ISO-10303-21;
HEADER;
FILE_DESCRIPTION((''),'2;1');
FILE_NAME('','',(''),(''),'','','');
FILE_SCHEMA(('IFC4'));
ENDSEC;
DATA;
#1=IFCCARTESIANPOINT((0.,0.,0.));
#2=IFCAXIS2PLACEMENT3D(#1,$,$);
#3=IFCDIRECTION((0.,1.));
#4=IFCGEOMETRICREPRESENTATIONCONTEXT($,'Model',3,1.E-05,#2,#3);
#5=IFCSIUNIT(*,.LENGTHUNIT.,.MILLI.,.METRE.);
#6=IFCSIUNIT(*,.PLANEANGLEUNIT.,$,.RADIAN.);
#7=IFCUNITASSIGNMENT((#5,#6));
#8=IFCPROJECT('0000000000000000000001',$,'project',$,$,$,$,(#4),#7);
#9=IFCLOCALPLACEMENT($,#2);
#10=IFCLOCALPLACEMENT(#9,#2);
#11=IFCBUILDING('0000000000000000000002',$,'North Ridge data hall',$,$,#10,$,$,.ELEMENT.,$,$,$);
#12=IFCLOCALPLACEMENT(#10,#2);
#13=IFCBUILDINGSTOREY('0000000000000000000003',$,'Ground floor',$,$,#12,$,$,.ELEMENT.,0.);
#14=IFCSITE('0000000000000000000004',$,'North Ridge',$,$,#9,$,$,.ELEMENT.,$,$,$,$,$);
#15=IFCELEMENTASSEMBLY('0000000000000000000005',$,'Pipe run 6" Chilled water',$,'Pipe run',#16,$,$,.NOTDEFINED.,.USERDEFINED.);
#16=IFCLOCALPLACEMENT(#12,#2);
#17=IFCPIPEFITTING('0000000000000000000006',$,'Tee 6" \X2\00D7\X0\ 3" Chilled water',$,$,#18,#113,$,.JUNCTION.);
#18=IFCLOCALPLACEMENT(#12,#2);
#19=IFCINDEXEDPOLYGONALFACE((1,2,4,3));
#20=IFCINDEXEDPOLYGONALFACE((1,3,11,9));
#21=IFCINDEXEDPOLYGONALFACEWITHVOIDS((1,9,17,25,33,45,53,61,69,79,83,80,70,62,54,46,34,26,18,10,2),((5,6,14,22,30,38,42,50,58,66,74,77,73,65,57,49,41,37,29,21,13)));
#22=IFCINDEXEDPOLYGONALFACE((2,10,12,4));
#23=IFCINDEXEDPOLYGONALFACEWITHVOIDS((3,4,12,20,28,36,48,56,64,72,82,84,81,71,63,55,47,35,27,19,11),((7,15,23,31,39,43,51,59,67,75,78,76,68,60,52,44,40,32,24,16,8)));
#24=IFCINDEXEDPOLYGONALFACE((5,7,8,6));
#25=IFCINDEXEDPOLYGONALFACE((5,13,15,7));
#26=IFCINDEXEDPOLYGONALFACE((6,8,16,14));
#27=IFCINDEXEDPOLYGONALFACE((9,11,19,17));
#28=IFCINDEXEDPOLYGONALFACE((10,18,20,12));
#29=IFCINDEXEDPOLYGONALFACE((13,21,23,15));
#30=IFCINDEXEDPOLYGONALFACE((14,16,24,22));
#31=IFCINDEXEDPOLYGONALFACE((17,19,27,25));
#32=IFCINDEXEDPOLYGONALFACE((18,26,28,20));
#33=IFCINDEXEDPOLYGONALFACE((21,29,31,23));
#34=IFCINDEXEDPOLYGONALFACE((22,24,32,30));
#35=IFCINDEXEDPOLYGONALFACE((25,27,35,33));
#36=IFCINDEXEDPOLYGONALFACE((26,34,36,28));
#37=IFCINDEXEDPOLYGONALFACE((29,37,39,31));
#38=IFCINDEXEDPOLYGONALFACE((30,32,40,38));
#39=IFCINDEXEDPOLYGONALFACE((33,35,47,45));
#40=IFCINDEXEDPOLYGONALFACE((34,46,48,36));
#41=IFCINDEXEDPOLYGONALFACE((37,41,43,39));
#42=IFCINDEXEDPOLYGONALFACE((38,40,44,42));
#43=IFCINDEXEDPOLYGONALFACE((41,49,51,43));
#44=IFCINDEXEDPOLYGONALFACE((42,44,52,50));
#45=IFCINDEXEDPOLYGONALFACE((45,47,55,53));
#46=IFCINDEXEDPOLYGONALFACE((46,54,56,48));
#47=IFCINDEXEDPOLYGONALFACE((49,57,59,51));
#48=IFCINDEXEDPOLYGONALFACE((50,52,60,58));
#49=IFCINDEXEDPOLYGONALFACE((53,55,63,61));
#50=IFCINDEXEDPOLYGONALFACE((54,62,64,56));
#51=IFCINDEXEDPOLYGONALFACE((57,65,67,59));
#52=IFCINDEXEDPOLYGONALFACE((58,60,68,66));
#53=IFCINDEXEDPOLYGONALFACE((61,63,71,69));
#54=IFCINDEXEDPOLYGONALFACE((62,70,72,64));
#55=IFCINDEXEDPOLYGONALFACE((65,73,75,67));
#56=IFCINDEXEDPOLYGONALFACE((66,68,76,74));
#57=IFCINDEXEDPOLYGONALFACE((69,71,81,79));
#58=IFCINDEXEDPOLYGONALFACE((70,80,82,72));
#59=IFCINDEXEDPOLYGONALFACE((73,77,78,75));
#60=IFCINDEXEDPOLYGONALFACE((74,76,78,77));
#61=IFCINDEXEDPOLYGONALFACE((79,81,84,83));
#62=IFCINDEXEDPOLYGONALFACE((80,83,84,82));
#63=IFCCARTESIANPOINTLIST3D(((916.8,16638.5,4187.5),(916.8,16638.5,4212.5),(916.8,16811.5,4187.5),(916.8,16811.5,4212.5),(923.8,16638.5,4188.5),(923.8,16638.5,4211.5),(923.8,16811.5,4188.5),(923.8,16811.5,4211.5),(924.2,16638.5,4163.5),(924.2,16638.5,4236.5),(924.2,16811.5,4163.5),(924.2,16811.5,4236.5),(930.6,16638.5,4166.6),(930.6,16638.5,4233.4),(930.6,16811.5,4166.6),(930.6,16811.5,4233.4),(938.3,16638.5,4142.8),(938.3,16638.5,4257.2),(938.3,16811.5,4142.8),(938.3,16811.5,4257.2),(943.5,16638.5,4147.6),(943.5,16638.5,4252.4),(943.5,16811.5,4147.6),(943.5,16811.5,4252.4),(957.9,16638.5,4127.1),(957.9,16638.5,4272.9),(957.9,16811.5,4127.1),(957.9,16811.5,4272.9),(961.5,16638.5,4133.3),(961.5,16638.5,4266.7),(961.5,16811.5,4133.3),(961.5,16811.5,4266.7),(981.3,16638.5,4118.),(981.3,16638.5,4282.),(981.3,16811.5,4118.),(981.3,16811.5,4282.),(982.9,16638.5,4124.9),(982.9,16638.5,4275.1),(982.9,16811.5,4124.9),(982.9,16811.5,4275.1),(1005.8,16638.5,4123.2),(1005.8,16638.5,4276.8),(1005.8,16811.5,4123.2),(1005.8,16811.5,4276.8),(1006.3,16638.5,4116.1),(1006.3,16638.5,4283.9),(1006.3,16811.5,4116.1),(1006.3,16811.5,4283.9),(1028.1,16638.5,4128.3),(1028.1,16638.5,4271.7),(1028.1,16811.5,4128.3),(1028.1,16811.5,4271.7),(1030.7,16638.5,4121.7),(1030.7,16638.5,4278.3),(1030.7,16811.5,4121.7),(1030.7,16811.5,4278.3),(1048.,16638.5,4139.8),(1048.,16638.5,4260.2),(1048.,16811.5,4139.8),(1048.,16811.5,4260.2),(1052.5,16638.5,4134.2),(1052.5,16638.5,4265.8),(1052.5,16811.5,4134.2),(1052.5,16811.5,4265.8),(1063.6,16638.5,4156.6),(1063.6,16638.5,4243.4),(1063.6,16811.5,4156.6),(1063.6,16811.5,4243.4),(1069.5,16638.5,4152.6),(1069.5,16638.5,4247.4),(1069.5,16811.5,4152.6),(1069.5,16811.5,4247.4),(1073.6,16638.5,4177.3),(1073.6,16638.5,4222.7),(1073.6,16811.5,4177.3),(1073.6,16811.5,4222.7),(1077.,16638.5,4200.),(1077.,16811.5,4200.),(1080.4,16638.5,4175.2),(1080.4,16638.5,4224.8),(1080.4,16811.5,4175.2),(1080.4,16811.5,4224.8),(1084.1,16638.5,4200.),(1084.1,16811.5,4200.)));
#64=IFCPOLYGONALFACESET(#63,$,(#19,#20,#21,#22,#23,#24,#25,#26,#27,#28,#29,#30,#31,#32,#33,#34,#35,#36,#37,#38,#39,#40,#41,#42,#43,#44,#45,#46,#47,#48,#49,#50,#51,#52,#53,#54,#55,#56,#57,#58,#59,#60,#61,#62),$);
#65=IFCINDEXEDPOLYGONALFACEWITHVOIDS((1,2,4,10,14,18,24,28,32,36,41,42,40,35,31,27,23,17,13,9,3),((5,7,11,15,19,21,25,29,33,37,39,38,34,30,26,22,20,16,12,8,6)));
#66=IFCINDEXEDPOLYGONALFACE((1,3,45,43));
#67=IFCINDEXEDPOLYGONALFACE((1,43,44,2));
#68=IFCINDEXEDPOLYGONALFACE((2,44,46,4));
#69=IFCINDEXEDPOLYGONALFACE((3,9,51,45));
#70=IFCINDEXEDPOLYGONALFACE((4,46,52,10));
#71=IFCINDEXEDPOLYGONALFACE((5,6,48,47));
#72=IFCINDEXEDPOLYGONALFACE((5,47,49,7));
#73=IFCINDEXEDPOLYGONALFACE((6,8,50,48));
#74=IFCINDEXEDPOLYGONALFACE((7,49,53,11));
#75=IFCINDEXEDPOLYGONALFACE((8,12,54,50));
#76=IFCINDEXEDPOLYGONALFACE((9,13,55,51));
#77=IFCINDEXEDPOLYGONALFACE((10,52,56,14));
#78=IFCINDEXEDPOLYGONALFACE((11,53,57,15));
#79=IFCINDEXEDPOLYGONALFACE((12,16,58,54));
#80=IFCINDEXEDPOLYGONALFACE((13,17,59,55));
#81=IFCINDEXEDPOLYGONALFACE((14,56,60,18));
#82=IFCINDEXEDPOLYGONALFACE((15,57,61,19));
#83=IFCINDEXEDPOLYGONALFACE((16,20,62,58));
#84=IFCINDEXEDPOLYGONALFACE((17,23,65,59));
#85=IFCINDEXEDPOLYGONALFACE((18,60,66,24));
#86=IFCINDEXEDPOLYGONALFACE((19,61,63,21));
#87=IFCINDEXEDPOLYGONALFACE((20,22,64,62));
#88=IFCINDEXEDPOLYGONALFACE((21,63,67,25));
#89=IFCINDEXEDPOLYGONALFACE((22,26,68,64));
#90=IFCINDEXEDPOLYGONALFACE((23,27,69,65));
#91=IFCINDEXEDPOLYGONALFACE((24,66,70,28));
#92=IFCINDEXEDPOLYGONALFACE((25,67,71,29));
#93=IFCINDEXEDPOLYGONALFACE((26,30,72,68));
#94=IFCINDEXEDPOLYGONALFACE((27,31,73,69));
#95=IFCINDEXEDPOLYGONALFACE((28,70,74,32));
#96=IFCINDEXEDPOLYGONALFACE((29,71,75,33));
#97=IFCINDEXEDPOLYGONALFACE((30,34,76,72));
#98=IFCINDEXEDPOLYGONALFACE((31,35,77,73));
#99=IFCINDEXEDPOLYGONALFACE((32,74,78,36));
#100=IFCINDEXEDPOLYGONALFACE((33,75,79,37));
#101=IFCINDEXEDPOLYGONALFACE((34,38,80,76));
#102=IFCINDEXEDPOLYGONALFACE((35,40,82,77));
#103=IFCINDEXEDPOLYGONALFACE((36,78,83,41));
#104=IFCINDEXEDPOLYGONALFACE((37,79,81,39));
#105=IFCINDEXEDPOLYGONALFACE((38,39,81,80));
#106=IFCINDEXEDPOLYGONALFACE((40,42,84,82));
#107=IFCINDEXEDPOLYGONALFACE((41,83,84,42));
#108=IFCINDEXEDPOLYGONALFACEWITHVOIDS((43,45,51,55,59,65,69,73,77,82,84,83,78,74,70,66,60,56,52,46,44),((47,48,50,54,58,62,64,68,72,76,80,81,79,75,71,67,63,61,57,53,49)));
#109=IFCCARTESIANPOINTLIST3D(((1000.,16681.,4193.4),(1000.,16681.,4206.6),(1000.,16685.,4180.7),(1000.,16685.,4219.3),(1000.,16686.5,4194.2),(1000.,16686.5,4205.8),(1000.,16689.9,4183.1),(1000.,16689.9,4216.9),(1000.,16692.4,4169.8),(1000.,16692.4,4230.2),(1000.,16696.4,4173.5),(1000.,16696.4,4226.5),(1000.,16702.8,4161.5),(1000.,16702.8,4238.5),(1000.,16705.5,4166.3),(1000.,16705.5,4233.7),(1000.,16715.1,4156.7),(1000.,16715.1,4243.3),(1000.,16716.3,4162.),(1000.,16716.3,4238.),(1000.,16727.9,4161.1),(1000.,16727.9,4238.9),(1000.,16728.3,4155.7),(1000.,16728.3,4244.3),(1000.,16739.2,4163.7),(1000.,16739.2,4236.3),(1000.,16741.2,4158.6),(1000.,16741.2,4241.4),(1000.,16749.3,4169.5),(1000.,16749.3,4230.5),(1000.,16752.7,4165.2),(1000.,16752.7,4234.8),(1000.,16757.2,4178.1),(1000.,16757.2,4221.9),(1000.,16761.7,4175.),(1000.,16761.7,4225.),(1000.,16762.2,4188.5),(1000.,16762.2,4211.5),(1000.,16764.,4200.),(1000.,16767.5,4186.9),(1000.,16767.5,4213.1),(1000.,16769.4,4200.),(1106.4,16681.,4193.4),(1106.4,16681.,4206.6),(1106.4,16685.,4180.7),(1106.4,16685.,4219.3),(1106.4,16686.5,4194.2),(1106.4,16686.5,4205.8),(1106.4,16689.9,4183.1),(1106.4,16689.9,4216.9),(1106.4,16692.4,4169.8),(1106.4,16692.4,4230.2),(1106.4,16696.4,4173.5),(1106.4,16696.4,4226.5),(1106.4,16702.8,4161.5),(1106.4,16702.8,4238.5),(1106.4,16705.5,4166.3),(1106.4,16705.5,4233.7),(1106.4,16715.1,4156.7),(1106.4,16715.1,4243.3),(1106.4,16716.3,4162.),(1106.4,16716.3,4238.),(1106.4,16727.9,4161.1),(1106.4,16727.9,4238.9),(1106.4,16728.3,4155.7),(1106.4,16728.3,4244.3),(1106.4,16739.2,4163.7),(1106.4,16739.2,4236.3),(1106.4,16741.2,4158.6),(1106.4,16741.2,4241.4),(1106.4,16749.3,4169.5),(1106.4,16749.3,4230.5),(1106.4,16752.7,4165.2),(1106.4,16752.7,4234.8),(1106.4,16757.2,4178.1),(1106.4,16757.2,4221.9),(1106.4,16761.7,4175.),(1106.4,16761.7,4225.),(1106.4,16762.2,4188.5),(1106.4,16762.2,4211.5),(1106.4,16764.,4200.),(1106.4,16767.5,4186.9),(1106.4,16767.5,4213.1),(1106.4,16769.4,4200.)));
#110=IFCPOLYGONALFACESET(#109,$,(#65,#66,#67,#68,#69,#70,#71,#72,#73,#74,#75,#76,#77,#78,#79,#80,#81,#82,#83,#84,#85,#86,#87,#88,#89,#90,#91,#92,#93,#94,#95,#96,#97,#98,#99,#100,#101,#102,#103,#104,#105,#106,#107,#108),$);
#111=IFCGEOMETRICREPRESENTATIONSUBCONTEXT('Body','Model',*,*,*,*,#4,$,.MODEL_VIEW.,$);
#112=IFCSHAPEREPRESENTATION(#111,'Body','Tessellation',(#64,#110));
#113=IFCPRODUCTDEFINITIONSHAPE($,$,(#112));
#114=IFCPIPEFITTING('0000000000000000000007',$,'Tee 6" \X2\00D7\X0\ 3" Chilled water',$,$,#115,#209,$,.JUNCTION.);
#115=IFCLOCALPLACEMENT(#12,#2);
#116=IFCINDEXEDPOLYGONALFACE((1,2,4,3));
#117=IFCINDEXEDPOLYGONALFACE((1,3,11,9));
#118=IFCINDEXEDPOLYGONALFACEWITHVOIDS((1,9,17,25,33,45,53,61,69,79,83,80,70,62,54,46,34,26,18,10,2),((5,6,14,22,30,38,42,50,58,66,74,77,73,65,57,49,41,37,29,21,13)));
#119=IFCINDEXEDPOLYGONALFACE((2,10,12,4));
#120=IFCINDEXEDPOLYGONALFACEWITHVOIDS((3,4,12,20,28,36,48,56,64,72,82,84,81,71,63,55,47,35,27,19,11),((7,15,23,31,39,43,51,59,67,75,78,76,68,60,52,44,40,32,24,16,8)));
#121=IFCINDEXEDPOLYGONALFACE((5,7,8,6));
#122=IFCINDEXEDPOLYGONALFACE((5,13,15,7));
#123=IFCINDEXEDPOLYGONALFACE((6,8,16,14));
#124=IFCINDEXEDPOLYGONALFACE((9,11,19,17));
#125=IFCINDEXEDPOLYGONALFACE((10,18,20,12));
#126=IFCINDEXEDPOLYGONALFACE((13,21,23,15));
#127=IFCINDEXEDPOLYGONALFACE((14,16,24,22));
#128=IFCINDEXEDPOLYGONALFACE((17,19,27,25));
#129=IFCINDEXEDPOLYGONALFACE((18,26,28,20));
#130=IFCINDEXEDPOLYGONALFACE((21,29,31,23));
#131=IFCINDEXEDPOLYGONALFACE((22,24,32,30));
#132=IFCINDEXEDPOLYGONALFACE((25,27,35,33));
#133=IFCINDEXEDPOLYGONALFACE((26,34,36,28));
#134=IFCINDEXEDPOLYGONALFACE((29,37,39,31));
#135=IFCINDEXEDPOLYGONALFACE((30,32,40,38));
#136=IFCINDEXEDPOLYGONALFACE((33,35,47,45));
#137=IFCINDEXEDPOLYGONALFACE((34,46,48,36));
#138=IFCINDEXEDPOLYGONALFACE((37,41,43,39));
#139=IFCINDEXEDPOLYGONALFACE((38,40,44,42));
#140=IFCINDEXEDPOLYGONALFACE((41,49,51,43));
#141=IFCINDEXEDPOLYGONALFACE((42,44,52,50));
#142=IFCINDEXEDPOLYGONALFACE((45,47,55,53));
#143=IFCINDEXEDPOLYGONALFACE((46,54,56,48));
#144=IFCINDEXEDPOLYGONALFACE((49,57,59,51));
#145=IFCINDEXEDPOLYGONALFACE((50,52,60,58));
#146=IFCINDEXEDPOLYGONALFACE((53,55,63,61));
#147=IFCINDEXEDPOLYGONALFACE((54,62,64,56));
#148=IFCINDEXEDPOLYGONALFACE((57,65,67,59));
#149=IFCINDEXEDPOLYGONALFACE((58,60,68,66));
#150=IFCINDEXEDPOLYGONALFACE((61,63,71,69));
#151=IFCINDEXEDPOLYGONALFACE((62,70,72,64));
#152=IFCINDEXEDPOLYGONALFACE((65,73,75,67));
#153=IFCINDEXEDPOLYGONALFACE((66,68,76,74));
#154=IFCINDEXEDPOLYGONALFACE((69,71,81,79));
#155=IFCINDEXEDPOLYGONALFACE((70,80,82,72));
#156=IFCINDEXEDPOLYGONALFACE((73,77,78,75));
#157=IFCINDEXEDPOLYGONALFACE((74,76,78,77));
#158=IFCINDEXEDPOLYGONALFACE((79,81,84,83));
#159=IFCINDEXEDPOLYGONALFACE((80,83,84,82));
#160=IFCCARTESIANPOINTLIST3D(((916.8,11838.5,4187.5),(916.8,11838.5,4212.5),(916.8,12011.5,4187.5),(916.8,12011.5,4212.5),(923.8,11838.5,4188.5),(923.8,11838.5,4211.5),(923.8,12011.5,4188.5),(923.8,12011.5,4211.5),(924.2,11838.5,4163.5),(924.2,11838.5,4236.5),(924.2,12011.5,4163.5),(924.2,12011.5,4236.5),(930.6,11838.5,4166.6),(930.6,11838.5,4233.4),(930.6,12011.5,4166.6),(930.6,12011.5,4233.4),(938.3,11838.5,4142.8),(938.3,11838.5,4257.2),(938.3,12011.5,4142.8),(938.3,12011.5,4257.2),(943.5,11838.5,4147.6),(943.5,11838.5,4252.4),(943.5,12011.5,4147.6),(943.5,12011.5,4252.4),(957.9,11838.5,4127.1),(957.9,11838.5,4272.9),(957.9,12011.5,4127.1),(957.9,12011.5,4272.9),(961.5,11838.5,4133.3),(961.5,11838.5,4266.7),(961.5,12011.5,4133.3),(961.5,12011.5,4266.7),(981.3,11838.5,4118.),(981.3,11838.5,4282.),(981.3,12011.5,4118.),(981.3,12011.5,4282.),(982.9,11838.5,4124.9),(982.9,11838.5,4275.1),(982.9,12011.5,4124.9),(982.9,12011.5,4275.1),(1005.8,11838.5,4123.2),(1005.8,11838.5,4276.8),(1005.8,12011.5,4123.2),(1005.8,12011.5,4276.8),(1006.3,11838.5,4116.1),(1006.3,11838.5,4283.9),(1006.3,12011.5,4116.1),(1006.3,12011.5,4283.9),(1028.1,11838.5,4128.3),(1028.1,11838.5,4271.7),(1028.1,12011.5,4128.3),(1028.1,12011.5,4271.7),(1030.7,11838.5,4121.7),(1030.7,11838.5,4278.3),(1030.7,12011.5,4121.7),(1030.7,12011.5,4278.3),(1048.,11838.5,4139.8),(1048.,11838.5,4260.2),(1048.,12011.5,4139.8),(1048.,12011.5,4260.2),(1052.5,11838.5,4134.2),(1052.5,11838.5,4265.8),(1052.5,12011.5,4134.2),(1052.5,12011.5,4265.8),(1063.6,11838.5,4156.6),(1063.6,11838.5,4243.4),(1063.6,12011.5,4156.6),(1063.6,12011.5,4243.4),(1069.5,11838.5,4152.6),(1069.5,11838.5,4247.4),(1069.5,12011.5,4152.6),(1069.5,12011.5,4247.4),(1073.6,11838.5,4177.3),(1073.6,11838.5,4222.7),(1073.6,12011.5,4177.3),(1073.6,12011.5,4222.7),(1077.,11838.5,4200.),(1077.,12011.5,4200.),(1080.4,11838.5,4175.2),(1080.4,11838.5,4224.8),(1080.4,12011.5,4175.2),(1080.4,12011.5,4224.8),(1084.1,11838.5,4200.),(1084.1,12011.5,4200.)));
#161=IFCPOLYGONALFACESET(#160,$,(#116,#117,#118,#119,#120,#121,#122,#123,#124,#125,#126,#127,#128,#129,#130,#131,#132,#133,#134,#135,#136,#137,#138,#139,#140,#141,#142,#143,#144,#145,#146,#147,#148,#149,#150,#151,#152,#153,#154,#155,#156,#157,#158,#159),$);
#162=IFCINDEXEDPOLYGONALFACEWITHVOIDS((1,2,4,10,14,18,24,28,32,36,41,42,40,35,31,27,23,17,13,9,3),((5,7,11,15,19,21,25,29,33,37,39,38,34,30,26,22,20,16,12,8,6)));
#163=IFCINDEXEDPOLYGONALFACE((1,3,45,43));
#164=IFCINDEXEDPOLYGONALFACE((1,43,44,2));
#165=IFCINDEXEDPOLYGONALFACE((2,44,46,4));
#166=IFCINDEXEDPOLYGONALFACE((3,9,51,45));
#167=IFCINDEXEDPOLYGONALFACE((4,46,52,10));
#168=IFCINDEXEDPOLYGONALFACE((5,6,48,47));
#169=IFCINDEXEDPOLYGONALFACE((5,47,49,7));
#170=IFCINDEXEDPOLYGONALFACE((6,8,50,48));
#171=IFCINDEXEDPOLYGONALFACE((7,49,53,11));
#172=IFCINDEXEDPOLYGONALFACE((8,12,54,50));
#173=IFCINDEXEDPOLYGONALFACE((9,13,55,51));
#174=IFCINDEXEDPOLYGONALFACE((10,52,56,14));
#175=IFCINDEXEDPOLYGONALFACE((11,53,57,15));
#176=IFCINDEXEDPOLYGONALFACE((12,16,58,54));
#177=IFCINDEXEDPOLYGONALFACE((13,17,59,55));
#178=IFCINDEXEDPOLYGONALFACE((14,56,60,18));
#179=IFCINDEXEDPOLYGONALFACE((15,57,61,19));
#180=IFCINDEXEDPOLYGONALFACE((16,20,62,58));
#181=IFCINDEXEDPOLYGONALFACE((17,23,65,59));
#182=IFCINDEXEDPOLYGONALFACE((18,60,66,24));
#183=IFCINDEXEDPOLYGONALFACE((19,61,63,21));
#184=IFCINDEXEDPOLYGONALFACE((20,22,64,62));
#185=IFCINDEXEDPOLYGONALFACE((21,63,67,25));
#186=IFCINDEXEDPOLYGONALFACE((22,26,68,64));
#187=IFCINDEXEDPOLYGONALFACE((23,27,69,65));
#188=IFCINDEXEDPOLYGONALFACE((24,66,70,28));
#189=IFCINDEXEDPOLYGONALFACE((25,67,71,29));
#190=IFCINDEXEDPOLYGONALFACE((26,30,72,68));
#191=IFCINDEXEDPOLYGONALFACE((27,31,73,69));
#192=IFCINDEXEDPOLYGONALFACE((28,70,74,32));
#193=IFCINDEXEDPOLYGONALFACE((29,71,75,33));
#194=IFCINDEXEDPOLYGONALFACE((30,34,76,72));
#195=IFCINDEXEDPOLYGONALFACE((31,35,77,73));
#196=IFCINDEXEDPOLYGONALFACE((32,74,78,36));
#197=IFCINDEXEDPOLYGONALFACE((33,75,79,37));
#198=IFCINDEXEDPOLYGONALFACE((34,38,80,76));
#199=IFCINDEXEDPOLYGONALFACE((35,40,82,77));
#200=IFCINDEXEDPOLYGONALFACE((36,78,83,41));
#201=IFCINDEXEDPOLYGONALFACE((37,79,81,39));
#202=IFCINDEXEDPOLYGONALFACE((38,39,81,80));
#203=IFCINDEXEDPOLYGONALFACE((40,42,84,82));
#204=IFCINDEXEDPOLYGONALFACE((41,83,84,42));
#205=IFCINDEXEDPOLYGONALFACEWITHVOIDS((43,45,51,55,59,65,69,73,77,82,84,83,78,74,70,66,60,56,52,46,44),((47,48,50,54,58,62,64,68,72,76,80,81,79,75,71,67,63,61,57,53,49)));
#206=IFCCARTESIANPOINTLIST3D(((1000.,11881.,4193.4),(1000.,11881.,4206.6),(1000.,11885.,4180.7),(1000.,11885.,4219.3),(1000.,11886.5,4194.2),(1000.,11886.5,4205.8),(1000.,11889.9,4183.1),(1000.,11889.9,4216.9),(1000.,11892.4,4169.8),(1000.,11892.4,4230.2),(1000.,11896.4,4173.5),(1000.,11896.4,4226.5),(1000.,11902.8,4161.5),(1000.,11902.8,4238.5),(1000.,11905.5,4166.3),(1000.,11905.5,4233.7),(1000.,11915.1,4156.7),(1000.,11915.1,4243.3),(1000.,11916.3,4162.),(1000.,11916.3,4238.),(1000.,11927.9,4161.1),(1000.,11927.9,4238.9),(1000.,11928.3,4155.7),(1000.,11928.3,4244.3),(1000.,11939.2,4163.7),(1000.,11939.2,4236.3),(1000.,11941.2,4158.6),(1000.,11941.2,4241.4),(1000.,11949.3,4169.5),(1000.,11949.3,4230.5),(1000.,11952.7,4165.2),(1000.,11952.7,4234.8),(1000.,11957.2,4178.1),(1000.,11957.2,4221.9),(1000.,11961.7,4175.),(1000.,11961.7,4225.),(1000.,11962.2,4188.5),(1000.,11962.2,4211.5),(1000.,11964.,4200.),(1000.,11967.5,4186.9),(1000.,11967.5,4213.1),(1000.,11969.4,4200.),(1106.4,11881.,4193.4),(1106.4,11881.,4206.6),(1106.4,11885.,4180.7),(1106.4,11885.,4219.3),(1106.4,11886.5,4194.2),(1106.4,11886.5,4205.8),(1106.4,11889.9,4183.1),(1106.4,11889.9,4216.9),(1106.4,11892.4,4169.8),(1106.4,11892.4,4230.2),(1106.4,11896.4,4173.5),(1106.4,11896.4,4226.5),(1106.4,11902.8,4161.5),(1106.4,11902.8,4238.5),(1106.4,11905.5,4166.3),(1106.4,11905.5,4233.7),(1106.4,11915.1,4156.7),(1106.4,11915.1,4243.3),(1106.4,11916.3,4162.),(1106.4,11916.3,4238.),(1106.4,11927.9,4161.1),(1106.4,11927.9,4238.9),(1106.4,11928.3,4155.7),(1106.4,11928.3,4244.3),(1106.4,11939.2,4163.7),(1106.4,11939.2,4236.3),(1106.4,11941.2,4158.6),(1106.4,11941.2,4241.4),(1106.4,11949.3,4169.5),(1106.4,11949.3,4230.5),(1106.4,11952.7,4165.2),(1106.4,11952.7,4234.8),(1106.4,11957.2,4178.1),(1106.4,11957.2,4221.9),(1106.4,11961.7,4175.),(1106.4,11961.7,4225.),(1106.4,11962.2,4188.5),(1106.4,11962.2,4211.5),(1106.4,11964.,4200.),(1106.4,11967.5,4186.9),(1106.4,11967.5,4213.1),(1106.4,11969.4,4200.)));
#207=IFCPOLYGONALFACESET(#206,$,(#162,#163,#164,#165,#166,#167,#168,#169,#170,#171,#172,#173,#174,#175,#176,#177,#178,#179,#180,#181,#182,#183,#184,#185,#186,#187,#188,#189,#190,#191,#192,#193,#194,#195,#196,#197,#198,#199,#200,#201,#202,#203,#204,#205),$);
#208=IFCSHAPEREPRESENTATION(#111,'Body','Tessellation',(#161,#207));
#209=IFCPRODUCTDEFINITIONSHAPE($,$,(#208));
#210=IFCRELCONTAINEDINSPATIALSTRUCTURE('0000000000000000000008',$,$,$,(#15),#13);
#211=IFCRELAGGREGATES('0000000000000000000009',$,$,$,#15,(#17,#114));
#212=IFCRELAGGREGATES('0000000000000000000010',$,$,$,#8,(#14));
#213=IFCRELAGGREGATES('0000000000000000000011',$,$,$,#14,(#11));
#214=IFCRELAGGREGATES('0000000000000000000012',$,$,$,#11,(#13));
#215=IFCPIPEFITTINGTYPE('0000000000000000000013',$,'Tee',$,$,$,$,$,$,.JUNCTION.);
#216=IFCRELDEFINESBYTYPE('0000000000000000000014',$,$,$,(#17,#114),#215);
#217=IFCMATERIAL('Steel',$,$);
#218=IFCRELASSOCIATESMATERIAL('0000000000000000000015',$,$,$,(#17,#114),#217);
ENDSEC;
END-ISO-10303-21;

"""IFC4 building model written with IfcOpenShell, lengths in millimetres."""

from ifc_helpers import new_model, si_unit, direction, frame, origin, origin_with_axes, origin_2d, place, context, subcontext, project, spatial, hollow_circle, extrude, material, type_object, element, aggregate, save


model = new_model("IFC4")

# Units and contexts
model_context = context("Model", 3, precision=1e-05, world=origin(), true_north=direction((0.0, 1.0)))
body_context = subcontext(model_context, "Body", "Model", "MODEL_VIEW")
ifc_project = project(units=[si_unit("LENGTHUNIT", "METRE", prefix="MILLI"), si_unit("PLANEANGLEUNIT", "RADIAN")], contexts=[model_context])

# Site, building, storey
site_placement = place(None, origin())
site = spatial("IfcSite", under=ifc_project, at=site_placement, Name="North Ridge", CompositionType="ELEMENT")
building_placement = place(site_placement, origin())
building = spatial("IfcBuilding", under=site, at=building_placement, Name="North Ridge data hall", CompositionType="ELEMENT")
storey_placement = place(building_placement, origin())
storey = spatial("IfcBuildingStorey", under=building, at=storey_placement, Name="Ground floor", CompositionType="ELEMENT", Elevation=0.0)

# Element assembly
assembly_1_placement = place(storey_placement, origin_with_axes())
assembly_1 = element("IfcElementAssembly", 1, at=assembly_1_placement, inside=storey, Name="Pipe run 6\" Chilled water", ObjectType="Pipe run", AssemblyPlace="NOTDEFINED", PredefinedType="USERDEFINED")
ifc_material_1 = material(Name="Steel")

# Pipe fittings
pipe_fitting_type_1 = type_object("IfcPipeFittingType", Name="Tee", PredefinedType="JUNCTION")
pipe_fitting_1_placement = place(storey_placement, origin_with_axes())
pipe_fitting_1 = element("IfcPipeFitting", 2, at=pipe_fitting_1_placement, type_object=pipe_fitting_type_1, material=ifc_material_1, Name="Tee 6\" × 3\" Chilled water", PredefinedType="JUNCTION", context=body_context, shape_type="SweptSolid", body=[
    extrude(hollow_circle(Radius=84.1, WallThickness=7.1, at=origin_2d()), frame((1000.0, 16811.5, 4200.0), z_axis=(0.0, -1.0, 0.0), x_axis=(1.0, 0.0, 0.0)), (0.0, 0.0, 1.0), 173.0),
    extrude(hollow_circle(Radius=44.5, WallThickness=5.5, at=origin_2d()), frame((1000.0, 16725.0, 4200.0), z_axis=(1.0, 0.0, 0.0), x_axis=(0.0, 1.0, 0.0)), (0.0, 0.0, 1.0), 106.4),
])
pipe_fitting_2_placement = place(storey_placement, origin_with_axes())
pipe_fitting_2 = element("IfcPipeFitting", 3, at=pipe_fitting_2_placement, type_object=pipe_fitting_type_1, material=ifc_material_1, Name="Tee 6\" × 3\" Chilled water", PredefinedType="JUNCTION", context=body_context, shape_type="SweptSolid", body=[
    extrude(hollow_circle(Radius=84.1, WallThickness=7.1, at=origin_2d()), frame((1000.0, 12011.5, 4200.0), z_axis=(0.0, -1.0, 0.0), x_axis=(1.0, 0.0, 0.0)), (0.0, 0.0, 1.0), 173.0),
    extrude(hollow_circle(Radius=44.5, WallThickness=5.5, at=origin_2d()), frame((1000.0, 11925.0, 4200.0), z_axis=(1.0, 0.0, 0.0), x_axis=(0.0, 1.0, 0.0)), (0.0, 0.0, 1.0), 106.4),
])
aggregate(assembly_1, [pipe_fitting_1, pipe_fitting_2])

save(model, "model.ifc")
